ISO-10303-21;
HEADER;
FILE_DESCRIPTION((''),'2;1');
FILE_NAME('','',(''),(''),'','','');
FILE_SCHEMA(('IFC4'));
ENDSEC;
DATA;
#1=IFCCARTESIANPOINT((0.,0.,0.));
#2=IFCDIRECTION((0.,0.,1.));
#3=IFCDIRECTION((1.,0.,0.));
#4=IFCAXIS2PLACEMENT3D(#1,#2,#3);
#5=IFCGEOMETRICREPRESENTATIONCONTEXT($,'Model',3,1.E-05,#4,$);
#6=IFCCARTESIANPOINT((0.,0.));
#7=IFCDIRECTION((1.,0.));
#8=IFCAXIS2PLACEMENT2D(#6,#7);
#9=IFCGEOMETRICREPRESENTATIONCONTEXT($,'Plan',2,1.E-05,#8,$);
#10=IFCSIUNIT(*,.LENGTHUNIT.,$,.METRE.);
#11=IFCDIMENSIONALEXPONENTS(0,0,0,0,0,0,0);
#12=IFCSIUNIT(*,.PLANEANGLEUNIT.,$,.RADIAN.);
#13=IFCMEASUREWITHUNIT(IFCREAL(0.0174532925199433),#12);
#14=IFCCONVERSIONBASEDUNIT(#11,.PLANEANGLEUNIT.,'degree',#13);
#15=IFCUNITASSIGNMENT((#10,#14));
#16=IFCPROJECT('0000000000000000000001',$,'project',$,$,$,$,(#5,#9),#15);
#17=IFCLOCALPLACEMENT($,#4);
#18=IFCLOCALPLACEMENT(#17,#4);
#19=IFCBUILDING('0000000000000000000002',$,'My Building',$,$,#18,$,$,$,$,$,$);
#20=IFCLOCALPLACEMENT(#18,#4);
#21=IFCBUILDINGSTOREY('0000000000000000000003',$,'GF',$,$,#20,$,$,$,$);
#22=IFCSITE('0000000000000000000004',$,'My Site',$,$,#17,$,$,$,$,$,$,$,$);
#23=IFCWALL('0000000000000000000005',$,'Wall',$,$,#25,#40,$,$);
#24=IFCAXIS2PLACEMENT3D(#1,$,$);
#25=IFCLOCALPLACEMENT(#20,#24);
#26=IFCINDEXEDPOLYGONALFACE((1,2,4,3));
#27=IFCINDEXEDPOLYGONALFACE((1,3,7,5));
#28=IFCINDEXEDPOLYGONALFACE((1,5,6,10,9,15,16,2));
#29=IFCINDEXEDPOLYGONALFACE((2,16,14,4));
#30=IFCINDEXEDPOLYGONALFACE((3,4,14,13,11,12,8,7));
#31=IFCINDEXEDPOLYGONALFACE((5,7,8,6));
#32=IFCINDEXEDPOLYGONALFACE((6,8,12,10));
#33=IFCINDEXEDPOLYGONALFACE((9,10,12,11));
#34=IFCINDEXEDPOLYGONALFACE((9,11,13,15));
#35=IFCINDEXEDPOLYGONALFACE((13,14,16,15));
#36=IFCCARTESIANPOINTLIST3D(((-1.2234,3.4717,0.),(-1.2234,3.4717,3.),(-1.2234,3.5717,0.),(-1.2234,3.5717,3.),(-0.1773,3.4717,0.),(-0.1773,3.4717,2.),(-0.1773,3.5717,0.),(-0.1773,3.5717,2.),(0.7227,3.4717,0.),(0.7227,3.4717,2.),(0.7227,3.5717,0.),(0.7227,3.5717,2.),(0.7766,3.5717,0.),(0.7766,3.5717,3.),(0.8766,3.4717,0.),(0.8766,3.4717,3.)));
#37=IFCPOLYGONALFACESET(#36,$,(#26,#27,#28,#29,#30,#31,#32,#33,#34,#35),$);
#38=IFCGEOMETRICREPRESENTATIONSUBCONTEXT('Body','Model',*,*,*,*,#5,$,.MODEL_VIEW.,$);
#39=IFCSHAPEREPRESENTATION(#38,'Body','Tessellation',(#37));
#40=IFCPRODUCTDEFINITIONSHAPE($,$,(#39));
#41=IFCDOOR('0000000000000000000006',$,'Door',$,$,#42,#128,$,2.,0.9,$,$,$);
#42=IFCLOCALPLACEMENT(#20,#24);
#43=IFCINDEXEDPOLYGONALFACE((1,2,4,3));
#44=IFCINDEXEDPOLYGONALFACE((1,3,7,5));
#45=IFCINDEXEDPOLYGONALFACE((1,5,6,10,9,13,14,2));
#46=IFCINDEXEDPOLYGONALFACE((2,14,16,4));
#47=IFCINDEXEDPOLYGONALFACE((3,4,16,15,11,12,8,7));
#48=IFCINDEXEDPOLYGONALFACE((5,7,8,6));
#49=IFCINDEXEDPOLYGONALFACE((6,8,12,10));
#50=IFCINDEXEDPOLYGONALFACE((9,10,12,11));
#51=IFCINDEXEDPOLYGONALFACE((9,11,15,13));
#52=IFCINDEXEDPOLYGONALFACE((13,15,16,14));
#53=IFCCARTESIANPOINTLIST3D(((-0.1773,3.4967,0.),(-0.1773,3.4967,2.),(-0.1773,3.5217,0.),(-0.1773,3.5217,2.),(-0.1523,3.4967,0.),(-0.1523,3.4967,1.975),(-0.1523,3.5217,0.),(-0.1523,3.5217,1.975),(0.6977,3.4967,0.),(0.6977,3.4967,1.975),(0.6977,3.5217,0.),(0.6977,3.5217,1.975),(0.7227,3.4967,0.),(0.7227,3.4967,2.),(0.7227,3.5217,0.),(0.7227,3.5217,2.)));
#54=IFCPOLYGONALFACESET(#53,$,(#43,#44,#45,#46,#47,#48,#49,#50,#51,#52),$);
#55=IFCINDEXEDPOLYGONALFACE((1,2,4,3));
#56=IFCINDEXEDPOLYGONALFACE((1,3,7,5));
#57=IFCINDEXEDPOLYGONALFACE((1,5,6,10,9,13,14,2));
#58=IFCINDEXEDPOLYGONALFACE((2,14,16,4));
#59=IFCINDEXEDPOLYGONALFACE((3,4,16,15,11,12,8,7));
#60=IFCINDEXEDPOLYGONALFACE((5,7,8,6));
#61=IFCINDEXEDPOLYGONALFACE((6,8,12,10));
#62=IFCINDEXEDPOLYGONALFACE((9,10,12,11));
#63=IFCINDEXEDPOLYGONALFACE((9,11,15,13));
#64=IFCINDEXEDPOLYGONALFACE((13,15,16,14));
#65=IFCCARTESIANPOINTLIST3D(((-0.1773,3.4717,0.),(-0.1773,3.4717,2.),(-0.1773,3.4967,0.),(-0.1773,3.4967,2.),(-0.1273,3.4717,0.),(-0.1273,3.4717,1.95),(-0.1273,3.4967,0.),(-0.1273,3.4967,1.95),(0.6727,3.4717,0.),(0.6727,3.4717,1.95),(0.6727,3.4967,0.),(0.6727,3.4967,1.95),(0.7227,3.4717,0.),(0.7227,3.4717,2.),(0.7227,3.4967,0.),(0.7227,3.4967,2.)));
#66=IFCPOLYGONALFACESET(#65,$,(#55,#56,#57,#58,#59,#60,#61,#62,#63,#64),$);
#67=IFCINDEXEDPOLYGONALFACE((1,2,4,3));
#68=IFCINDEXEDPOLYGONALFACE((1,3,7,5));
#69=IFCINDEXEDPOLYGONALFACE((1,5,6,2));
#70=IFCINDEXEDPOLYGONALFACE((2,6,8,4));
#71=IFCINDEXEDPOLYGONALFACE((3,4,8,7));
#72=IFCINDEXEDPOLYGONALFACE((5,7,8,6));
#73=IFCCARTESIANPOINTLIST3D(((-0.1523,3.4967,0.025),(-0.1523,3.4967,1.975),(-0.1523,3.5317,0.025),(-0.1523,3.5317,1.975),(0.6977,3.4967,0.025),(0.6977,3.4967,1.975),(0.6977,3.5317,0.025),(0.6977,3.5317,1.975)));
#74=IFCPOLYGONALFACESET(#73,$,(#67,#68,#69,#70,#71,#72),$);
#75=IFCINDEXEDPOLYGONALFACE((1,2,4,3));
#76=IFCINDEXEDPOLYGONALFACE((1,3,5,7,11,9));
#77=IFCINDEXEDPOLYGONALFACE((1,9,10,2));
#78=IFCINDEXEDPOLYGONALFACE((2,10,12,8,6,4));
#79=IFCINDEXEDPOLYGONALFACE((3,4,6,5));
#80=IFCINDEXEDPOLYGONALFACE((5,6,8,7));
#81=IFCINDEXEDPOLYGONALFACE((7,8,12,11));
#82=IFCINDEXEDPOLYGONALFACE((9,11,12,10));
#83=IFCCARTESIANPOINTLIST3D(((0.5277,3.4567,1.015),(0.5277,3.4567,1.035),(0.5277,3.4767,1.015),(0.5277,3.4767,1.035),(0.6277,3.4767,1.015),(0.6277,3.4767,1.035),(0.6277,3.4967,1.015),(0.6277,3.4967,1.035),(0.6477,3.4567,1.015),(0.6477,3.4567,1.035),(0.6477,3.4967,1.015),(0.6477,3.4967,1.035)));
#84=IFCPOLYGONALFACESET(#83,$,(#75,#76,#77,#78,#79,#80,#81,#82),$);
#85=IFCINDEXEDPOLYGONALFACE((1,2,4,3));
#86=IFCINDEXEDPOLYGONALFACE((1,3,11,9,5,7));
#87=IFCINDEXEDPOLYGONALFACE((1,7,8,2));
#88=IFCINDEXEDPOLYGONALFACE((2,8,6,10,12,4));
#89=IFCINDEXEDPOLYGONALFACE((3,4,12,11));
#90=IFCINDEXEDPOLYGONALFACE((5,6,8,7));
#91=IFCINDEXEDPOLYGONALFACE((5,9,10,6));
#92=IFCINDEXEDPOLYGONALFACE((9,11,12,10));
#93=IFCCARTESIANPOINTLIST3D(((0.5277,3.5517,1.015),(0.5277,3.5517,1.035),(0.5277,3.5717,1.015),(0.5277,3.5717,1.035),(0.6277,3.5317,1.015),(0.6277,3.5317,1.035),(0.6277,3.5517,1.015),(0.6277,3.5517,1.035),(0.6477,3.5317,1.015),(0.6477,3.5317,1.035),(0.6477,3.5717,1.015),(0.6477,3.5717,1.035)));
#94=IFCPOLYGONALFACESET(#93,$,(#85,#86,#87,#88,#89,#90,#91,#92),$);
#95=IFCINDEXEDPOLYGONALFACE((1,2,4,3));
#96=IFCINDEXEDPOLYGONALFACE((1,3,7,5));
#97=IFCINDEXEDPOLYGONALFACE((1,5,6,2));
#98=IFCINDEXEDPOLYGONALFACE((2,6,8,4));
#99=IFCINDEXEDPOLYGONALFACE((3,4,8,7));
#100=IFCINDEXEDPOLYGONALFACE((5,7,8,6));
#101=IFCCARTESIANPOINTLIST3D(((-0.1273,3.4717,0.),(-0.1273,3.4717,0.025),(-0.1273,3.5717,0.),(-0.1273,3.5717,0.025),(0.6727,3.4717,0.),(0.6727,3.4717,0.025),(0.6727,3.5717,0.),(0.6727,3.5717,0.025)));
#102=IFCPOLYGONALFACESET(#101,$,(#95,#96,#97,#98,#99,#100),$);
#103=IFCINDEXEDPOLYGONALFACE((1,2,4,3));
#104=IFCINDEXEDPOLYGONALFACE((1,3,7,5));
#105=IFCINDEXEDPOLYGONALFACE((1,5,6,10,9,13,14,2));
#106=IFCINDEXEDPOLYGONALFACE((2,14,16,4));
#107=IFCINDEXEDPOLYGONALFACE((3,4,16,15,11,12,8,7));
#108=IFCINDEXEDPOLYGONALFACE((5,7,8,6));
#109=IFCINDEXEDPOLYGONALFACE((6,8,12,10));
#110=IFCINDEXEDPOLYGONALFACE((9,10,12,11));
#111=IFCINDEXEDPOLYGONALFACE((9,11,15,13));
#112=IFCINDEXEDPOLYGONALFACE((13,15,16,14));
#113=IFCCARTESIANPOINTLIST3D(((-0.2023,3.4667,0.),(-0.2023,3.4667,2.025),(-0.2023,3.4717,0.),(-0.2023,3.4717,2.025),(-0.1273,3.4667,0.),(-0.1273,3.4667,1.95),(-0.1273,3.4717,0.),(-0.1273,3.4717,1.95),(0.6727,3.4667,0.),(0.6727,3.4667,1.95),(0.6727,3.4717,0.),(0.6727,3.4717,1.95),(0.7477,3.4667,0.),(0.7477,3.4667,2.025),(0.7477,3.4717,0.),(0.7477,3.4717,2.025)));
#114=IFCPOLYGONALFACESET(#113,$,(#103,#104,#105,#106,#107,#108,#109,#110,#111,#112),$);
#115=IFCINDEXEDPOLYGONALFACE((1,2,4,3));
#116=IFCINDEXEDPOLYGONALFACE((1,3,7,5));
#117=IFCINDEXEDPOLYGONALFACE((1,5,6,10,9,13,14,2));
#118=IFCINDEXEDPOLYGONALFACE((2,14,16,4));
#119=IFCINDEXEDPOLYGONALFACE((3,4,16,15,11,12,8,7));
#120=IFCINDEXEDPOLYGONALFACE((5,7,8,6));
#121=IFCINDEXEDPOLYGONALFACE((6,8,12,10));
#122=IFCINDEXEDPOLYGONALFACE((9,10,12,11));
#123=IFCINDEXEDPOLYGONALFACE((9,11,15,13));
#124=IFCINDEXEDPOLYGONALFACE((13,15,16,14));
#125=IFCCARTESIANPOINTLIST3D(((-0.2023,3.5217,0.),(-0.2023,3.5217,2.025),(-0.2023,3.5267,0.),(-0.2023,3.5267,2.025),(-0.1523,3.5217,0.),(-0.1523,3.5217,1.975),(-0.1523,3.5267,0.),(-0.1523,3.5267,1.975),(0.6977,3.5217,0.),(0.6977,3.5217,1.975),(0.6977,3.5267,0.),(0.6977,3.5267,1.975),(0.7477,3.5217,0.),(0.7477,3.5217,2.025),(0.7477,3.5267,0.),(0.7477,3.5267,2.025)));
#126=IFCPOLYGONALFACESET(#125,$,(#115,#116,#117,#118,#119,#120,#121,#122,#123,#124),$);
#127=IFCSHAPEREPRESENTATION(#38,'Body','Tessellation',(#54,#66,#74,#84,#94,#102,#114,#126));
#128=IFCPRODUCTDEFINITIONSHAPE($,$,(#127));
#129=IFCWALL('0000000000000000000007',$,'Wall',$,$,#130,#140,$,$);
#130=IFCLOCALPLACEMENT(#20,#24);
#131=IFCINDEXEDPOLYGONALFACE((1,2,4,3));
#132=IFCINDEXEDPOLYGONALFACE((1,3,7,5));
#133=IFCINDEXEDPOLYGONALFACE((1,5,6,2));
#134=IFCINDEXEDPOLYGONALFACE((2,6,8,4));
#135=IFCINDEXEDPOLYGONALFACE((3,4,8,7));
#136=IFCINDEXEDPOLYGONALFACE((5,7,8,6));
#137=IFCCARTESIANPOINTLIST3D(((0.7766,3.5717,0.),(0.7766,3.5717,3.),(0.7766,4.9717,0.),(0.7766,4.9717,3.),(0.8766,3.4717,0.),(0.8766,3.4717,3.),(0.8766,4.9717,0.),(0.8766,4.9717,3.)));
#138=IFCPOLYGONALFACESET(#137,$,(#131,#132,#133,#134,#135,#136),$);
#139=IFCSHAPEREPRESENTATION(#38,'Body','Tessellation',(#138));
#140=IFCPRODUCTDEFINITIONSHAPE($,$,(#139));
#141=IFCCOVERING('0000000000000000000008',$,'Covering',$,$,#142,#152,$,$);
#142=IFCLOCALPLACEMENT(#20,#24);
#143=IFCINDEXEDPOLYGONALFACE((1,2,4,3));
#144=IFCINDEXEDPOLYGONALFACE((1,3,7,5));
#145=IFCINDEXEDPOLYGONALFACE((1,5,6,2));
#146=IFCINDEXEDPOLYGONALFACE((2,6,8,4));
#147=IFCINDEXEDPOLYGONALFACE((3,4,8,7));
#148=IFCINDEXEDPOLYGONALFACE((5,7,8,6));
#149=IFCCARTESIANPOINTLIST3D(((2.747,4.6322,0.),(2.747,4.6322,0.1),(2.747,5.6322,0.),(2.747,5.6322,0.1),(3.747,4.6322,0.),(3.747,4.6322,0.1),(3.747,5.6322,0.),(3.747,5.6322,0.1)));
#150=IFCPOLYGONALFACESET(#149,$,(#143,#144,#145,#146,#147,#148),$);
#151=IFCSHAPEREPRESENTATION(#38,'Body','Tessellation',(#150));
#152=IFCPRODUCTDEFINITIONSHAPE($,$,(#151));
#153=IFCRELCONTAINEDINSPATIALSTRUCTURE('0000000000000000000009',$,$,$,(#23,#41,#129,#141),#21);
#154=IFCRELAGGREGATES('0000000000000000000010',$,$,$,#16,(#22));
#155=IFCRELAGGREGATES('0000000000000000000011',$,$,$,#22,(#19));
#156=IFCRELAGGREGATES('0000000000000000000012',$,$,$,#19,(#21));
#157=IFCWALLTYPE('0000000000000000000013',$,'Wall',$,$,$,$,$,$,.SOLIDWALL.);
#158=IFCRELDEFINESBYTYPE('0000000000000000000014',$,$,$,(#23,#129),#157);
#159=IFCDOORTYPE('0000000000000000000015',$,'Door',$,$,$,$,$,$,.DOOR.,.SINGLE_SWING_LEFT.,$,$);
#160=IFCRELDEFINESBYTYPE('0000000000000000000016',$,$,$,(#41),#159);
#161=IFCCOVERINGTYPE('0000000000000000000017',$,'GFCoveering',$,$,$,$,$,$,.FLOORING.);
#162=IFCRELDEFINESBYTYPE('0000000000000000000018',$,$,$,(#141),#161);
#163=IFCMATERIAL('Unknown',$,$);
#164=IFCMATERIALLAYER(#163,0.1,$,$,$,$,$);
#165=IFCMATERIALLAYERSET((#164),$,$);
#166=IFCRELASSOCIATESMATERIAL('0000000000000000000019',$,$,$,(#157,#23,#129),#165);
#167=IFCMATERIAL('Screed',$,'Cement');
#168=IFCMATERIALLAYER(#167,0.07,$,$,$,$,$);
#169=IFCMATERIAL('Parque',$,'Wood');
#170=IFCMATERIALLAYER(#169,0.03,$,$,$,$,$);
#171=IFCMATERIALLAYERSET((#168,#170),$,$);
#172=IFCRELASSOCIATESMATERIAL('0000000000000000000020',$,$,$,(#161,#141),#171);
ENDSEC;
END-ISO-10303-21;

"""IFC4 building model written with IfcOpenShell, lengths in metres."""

from ifc_helpers import new_model, entity, si_unit, converted_unit, frame, origin_with_axes, origin_2d_with_axis, place, context, subcontext, project, spatial, line, indexed_curve, outline, extrude, shape, source, transform, mapped, material, layer, layer_set, layer_usage, type_object, type_shapes, element, fill, save


model = new_model("IFC4")

# Units and contexts
model_context = context("Model", 3, precision=1e-05, world=origin_with_axes())
plan_context = context("Plan", 2, precision=1e-05, world=origin_2d_with_axis())
body_context_1 = subcontext(model_context, "Body", "Model", "MODEL_VIEW")
body_context_2 = subcontext(plan_context, "Body", "Plan", "PLAN_VIEW")
ifc_project = project(units=[si_unit("LENGTHUNIT", "METRE"), converted_unit("PLANEANGLEUNIT", "degree", entity("IfcReal", 0.0174532925199433), si_unit("PLANEANGLEUNIT", "RADIAN"), dimensions=[0, 0, 0, 0, 0, 0, 0])], contexts=[model_context, plan_context])

# Site, building, storey
site_placement = place(None, origin_with_axes())
site = spatial("IfcSite", under=ifc_project, at=site_placement, Name="My Site")
building_placement = place(site_placement, origin_with_axes())
building = spatial("IfcBuilding", under=site, at=building_placement, Name="My Building")
storey_placement = place(building_placement, origin_with_axes())
storey = spatial("IfcBuildingStorey", under=building, at=storey_placement, Name="GF")

# Shared definitions
ifc_material_1 = material(Name="Unknown")

# Shared definitions
ifc_layer_1 = layer(ifc_material_1, 0.1)
ifc_layer_set_1 = layer_set([ifc_layer_1])
wall_type = type_object("IfcWallType", Name="Wall", PredefinedType="SOLIDWALL", material=ifc_layer_set_1)

# Shared definitions
shared_shape_1 = source(origin_with_axes(), body_context_1, "Body", "SweptSolid", [
    extrude(outline(indexed_curve([(0.0, 0.0), (0.9, 0.0), (0.9, 2.0), (0.0, 2.0)], segments=[line(1, 2, 3, 4, 1)])), frame((0.0, -0.6, 0.0), z_axis=(0.0, -1.0, 0.0), x_axis=(1.0, 0.0, 0.0)), (0.0, 0.0, -1.0), 1.2),
])
door_type = type_object("IfcDoorType", Name="Door", OperationType="SINGLE_SWING_LEFT", PredefinedType="DOOR")
shared_shape_2 = source(origin_with_axes(), body_context_1, "Body", "SweptSolid", [
    extrude(outline(indexed_curve([(0.0, 0.0), (0.0, 2.0), (0.9, 2.0), (0.9, 0.0), (0.875, 0.0), (0.875, 1.975), (0.025, 1.975), (0.025, 0.0)], segments=[line(1, 2, 3, 4, 5, 6, 7, 8, 1)])), frame((0.0, 0.025, 0.0), z_axis=(0.0, -1.0, 0.0), x_axis=(1.0, 0.0, 0.0)), (0.0, 0.0, -1.0), 0.025),
    extrude(outline(indexed_curve([(0.0, 0.0), (0.0, 2.0), (0.9, 2.0), (0.9, 0.0), (0.85, 0.0), (0.85, 1.95), (0.05, 1.95), (0.05, 0.0)], segments=[line(1, 2, 3, 4, 5, 6, 7, 8, 1)])), frame((0.0, 0.0, 0.0), z_axis=(0.0, -1.0, 0.0), x_axis=(1.0, 0.0, 0.0)), (0.0, 0.0, -1.0), 0.025),
    extrude(outline(indexed_curve([(0.0, 0.0), (0.85, 0.0), (0.85, 0.035), (0.0, 0.035)], segments=[line(1, 2, 3, 4, 1)])), frame((0.025, 0.025, 0.025), z_axis=(0.0, 0.0, 1.0), x_axis=(1.0, 0.0, 0.0)), (0.0, 0.0, 1.0), 1.95),
    extrude(outline(indexed_curve([(0.0, 0.0), (0.0, -0.04), (-0.12, -0.04), (-0.12, -0.02), (-0.02, -0.02), (-0.02, 0.0)], segments=[line(1, 2, 3, 4, 5, 6, 1)])), frame((0.825, 0.025, 1.015), z_axis=(0.0, 0.0, 1.0), x_axis=(1.0, 0.0, 0.0)), (0.0, 0.0, 1.0), 0.02),
    extrude(outline(indexed_curve([(0.0, 0.0), (0.0, 0.04), (-0.12, 0.04), (-0.12, 0.02), (-0.02, 0.02), (-0.02, 0.0)], segments=[line(1, 2, 3, 4, 5, 6, 1)])), frame((0.825, 0.06, 1.015), z_axis=(0.0, 0.0, 1.0), x_axis=(1.0, 0.0, 0.0)), (0.0, 0.0, 1.0), 0.02),
    extrude(outline(indexed_curve([(0.0, 0.0), (0.8, 0.0), (0.8, 0.1), (0.0, 0.1)], segments=[line(1, 2, 3, 4, 1)])), frame((0.05, 0.0, 0.0), z_axis=(0.0, 0.0, 1.0), x_axis=(1.0, 0.0, 0.0)), (0.0, 0.0, 1.0), 0.025),
    extrude(outline(indexed_curve([(0.0, 0.0), (0.0, 2.025), (0.95, 2.025), (0.95, 0.0), (0.875, 0.0), (0.875, 1.95), (0.075, 1.95), (0.075, 0.0)], segments=[line(1, 2, 3, 4, 5, 6, 7, 8, 1)])), frame((-0.025, -0.005, 0.0), z_axis=(0.0, -1.0, 0.0), x_axis=(1.0, 0.0, 0.0)), (0.0, 0.0, -1.0), 0.005),
    extrude(outline(indexed_curve([(0.0, 0.0), (0.0, 2.025), (0.95, 2.025), (0.95, 0.0), (0.9, 0.0), (0.9, 1.975), (0.05, 1.975), (0.05, 0.0)], segments=[line(1, 2, 3, 4, 5, 6, 7, 8, 1)])), frame((-0.025, 0.05, 0.0), z_axis=(0.0, -1.0, 0.0), x_axis=(1.0, 0.0, 0.0)), (0.0, 0.0, -1.0), 0.005),
])
shared_shape_3 = source(origin_with_axes(), body_context_2, "Body", "Curve2D", [
    entity("IfcIndexedPolyCurve", entity("IfcCartesianPointList2D", [[0.0, 0.0], [0.0, 0.05], [0.025, 0.05], [0.025, 0.025], [0.05, 0.025], [0.05, 0.0]]), [entity("IfcLineIndex", [1, 2, 3, 4, 5, 6, 1])]),
    entity("IfcIndexedPolyCurve", entity("IfcCartesianPointList2D", [[0.9, 0.0], [0.9, 0.05], [0.875, 0.05], [0.875, 0.025], [0.85, 0.025], [0.85, 0.0]]), [entity("IfcLineIndex", [1, 2, 3, 4, 5, 6, 1])]),
    entity("IfcTrimmedCurve", entity("IfcEllipse", entity("IfcAxis2Placement2D", entity("IfcCartesianPoint", [0.06, 0.05]), entity("IfcDirection", [1.0, 0.0])), 0.815, 0.85), [entity("IfcCartesianPoint", [0.875, 0.05])], [entity("IfcCartesianPoint", [0.06, 0.9])], True, "CARTESIAN"),
    entity("IfcIndexedPolyCurve", entity("IfcCartesianPointList2D", [[0.025, 0.05], [0.06, 0.05], [0.06, 0.9], [0.025, 0.9]]), [entity("IfcLineIndex", [1, 2, 3, 4, 1])]),
])
type_shapes(door_type, [shared_shape_2, shared_shape_3])

# Wall, opening, door
ifc_layer_usage_1 = layer_usage(ifc_layer_set_1, "AXIS2", "POSITIVE", 0.0)
wall_1_placement = place(storey_placement, frame((-1.2234, 3.4717, 0.0), z_axis=(0.0, 0.0, 1.0), x_axis=(1.0, 0.0, 0.0)))
wall_1 = element("IfcWall", 1, at=wall_1_placement, inside=storey, type_object=wall_type, material=ifc_layer_usage_1, Name="Wall", context=body_context_1, shape_type="SweptSolid", body=[
    extrude(outline(indexed_curve([(0.0, 0.0), (0.0, 0.1), (2.0, 0.1), (2.1, 0.0)], segments=[line(1, 2, 3, 4, 1)])), origin_with_axes(), (0.0, 0.0, 1.0), 3.0),
])
opening_1_placement = place(wall_1_placement, frame((1.046, 0.0, 0.0), z_axis=(0.0, 0.0, 1.0), x_axis=(1.0, 0.0, 0.0)))
opening_1 = element("IfcOpeningElement", 2, at=opening_1_placement, cuts=wall_1, PredefinedType="OPENING", context=body_context_1, shape_type="MappedRepresentation", body=[
    mapped(shared_shape_1, transform((0.0, 0.0, 0.0), x_axis=(1.0, 0.0, 0.0), y_axis=(0.0, 1.0, 0.0), z_axis=(0.0, 0.0, 1.0), scale=1.0)),
])
door_1_placement = place(opening_1_placement, origin_with_axes())
door_1 = element("IfcDoor", 3, at=door_1_placement, inside=storey, type_object=door_type, Name="Door", OverallHeight=2.0, OverallWidth=0.9, shapes=[
    shape(body_context_1, "Body", "MappedRepresentation", [mapped(shared_shape_2, transform((0.0, 0.0, 0.0), x_axis=(1.0, 0.0, 0.0), y_axis=(0.0, 1.0, 0.0), z_axis=(0.0, 0.0, 1.0), scale=1.0))]),
    shape(body_context_2, "Body", "MappedRepresentation", [mapped(shared_shape_3, transform((0.0, 0.0, 0.0), x_axis=(1.0, 0.0, 0.0), y_axis=(0.0, 1.0, 0.0), z_axis=(0.0, 0.0, 1.0), scale=1.0))]),
])
fill(opening_1, door_1)

# Wall
ifc_layer_usage_2 = layer_usage(ifc_layer_set_1, "AXIS2", "POSITIVE", 0.0)
wall_2_placement = place(storey_placement, frame((0.8766, 3.4717, 0.0), z_axis=(0.0, 0.0, 1.0), x_axis=(0.0, 1.0, 0.0)))
element("IfcWall", 4, at=wall_2_placement, inside=storey, type_object=wall_type, material=ifc_layer_usage_2, Name="Wall", context=body_context_1, shape_type="SweptSolid", body=[
    extrude(outline(indexed_curve([(0.0, 0.0), (0.1, 0.1), (1.5, 0.1), (1.5, 0.0)], segments=[line(1, 2, 3, 4, 1)])), origin_with_axes(), (0.0, 0.0, 1.0), 3.0),
])

# Covering
ifc_material_2 = material(Name="Screed", Category="Cement")
ifc_layer_2 = layer(ifc_material_2, 0.07)
ifc_material_3 = material(Name="Parque", Category="Wood")
ifc_layer_3 = layer(ifc_material_3, 0.03)
ifc_layer_set_2 = layer_set([ifc_layer_2, ifc_layer_3])
ifc_layer_usage_3 = layer_usage(ifc_layer_set_2, "AXIS3", "POSITIVE", 0.0)
covering_type = type_object("IfcCoveringType", Name="GFCoveering", PredefinedType="FLOORING", material=ifc_layer_set_2)
covering_placement = place(storey_placement, frame((2.747, 4.6322, 0.0), z_axis=(0.0, 0.0, 1.0), x_axis=(1.0, 0.0, 0.0)))
element("IfcCovering", 5, at=covering_placement, inside=storey, type_object=covering_type, material=ifc_layer_usage_3, Name="Covering", context=body_context_1, shape_type="SweptSolid", body=[
    extrude(outline(indexed_curve([(0.0, 0.0), (1.0, 0.0), (1.0, 1.0), (0.0, 1.0), (0.0, 0.0)])), None, (0.0, 0.0, 1.0), 0.1),
])

save(model, "model.ifc")
